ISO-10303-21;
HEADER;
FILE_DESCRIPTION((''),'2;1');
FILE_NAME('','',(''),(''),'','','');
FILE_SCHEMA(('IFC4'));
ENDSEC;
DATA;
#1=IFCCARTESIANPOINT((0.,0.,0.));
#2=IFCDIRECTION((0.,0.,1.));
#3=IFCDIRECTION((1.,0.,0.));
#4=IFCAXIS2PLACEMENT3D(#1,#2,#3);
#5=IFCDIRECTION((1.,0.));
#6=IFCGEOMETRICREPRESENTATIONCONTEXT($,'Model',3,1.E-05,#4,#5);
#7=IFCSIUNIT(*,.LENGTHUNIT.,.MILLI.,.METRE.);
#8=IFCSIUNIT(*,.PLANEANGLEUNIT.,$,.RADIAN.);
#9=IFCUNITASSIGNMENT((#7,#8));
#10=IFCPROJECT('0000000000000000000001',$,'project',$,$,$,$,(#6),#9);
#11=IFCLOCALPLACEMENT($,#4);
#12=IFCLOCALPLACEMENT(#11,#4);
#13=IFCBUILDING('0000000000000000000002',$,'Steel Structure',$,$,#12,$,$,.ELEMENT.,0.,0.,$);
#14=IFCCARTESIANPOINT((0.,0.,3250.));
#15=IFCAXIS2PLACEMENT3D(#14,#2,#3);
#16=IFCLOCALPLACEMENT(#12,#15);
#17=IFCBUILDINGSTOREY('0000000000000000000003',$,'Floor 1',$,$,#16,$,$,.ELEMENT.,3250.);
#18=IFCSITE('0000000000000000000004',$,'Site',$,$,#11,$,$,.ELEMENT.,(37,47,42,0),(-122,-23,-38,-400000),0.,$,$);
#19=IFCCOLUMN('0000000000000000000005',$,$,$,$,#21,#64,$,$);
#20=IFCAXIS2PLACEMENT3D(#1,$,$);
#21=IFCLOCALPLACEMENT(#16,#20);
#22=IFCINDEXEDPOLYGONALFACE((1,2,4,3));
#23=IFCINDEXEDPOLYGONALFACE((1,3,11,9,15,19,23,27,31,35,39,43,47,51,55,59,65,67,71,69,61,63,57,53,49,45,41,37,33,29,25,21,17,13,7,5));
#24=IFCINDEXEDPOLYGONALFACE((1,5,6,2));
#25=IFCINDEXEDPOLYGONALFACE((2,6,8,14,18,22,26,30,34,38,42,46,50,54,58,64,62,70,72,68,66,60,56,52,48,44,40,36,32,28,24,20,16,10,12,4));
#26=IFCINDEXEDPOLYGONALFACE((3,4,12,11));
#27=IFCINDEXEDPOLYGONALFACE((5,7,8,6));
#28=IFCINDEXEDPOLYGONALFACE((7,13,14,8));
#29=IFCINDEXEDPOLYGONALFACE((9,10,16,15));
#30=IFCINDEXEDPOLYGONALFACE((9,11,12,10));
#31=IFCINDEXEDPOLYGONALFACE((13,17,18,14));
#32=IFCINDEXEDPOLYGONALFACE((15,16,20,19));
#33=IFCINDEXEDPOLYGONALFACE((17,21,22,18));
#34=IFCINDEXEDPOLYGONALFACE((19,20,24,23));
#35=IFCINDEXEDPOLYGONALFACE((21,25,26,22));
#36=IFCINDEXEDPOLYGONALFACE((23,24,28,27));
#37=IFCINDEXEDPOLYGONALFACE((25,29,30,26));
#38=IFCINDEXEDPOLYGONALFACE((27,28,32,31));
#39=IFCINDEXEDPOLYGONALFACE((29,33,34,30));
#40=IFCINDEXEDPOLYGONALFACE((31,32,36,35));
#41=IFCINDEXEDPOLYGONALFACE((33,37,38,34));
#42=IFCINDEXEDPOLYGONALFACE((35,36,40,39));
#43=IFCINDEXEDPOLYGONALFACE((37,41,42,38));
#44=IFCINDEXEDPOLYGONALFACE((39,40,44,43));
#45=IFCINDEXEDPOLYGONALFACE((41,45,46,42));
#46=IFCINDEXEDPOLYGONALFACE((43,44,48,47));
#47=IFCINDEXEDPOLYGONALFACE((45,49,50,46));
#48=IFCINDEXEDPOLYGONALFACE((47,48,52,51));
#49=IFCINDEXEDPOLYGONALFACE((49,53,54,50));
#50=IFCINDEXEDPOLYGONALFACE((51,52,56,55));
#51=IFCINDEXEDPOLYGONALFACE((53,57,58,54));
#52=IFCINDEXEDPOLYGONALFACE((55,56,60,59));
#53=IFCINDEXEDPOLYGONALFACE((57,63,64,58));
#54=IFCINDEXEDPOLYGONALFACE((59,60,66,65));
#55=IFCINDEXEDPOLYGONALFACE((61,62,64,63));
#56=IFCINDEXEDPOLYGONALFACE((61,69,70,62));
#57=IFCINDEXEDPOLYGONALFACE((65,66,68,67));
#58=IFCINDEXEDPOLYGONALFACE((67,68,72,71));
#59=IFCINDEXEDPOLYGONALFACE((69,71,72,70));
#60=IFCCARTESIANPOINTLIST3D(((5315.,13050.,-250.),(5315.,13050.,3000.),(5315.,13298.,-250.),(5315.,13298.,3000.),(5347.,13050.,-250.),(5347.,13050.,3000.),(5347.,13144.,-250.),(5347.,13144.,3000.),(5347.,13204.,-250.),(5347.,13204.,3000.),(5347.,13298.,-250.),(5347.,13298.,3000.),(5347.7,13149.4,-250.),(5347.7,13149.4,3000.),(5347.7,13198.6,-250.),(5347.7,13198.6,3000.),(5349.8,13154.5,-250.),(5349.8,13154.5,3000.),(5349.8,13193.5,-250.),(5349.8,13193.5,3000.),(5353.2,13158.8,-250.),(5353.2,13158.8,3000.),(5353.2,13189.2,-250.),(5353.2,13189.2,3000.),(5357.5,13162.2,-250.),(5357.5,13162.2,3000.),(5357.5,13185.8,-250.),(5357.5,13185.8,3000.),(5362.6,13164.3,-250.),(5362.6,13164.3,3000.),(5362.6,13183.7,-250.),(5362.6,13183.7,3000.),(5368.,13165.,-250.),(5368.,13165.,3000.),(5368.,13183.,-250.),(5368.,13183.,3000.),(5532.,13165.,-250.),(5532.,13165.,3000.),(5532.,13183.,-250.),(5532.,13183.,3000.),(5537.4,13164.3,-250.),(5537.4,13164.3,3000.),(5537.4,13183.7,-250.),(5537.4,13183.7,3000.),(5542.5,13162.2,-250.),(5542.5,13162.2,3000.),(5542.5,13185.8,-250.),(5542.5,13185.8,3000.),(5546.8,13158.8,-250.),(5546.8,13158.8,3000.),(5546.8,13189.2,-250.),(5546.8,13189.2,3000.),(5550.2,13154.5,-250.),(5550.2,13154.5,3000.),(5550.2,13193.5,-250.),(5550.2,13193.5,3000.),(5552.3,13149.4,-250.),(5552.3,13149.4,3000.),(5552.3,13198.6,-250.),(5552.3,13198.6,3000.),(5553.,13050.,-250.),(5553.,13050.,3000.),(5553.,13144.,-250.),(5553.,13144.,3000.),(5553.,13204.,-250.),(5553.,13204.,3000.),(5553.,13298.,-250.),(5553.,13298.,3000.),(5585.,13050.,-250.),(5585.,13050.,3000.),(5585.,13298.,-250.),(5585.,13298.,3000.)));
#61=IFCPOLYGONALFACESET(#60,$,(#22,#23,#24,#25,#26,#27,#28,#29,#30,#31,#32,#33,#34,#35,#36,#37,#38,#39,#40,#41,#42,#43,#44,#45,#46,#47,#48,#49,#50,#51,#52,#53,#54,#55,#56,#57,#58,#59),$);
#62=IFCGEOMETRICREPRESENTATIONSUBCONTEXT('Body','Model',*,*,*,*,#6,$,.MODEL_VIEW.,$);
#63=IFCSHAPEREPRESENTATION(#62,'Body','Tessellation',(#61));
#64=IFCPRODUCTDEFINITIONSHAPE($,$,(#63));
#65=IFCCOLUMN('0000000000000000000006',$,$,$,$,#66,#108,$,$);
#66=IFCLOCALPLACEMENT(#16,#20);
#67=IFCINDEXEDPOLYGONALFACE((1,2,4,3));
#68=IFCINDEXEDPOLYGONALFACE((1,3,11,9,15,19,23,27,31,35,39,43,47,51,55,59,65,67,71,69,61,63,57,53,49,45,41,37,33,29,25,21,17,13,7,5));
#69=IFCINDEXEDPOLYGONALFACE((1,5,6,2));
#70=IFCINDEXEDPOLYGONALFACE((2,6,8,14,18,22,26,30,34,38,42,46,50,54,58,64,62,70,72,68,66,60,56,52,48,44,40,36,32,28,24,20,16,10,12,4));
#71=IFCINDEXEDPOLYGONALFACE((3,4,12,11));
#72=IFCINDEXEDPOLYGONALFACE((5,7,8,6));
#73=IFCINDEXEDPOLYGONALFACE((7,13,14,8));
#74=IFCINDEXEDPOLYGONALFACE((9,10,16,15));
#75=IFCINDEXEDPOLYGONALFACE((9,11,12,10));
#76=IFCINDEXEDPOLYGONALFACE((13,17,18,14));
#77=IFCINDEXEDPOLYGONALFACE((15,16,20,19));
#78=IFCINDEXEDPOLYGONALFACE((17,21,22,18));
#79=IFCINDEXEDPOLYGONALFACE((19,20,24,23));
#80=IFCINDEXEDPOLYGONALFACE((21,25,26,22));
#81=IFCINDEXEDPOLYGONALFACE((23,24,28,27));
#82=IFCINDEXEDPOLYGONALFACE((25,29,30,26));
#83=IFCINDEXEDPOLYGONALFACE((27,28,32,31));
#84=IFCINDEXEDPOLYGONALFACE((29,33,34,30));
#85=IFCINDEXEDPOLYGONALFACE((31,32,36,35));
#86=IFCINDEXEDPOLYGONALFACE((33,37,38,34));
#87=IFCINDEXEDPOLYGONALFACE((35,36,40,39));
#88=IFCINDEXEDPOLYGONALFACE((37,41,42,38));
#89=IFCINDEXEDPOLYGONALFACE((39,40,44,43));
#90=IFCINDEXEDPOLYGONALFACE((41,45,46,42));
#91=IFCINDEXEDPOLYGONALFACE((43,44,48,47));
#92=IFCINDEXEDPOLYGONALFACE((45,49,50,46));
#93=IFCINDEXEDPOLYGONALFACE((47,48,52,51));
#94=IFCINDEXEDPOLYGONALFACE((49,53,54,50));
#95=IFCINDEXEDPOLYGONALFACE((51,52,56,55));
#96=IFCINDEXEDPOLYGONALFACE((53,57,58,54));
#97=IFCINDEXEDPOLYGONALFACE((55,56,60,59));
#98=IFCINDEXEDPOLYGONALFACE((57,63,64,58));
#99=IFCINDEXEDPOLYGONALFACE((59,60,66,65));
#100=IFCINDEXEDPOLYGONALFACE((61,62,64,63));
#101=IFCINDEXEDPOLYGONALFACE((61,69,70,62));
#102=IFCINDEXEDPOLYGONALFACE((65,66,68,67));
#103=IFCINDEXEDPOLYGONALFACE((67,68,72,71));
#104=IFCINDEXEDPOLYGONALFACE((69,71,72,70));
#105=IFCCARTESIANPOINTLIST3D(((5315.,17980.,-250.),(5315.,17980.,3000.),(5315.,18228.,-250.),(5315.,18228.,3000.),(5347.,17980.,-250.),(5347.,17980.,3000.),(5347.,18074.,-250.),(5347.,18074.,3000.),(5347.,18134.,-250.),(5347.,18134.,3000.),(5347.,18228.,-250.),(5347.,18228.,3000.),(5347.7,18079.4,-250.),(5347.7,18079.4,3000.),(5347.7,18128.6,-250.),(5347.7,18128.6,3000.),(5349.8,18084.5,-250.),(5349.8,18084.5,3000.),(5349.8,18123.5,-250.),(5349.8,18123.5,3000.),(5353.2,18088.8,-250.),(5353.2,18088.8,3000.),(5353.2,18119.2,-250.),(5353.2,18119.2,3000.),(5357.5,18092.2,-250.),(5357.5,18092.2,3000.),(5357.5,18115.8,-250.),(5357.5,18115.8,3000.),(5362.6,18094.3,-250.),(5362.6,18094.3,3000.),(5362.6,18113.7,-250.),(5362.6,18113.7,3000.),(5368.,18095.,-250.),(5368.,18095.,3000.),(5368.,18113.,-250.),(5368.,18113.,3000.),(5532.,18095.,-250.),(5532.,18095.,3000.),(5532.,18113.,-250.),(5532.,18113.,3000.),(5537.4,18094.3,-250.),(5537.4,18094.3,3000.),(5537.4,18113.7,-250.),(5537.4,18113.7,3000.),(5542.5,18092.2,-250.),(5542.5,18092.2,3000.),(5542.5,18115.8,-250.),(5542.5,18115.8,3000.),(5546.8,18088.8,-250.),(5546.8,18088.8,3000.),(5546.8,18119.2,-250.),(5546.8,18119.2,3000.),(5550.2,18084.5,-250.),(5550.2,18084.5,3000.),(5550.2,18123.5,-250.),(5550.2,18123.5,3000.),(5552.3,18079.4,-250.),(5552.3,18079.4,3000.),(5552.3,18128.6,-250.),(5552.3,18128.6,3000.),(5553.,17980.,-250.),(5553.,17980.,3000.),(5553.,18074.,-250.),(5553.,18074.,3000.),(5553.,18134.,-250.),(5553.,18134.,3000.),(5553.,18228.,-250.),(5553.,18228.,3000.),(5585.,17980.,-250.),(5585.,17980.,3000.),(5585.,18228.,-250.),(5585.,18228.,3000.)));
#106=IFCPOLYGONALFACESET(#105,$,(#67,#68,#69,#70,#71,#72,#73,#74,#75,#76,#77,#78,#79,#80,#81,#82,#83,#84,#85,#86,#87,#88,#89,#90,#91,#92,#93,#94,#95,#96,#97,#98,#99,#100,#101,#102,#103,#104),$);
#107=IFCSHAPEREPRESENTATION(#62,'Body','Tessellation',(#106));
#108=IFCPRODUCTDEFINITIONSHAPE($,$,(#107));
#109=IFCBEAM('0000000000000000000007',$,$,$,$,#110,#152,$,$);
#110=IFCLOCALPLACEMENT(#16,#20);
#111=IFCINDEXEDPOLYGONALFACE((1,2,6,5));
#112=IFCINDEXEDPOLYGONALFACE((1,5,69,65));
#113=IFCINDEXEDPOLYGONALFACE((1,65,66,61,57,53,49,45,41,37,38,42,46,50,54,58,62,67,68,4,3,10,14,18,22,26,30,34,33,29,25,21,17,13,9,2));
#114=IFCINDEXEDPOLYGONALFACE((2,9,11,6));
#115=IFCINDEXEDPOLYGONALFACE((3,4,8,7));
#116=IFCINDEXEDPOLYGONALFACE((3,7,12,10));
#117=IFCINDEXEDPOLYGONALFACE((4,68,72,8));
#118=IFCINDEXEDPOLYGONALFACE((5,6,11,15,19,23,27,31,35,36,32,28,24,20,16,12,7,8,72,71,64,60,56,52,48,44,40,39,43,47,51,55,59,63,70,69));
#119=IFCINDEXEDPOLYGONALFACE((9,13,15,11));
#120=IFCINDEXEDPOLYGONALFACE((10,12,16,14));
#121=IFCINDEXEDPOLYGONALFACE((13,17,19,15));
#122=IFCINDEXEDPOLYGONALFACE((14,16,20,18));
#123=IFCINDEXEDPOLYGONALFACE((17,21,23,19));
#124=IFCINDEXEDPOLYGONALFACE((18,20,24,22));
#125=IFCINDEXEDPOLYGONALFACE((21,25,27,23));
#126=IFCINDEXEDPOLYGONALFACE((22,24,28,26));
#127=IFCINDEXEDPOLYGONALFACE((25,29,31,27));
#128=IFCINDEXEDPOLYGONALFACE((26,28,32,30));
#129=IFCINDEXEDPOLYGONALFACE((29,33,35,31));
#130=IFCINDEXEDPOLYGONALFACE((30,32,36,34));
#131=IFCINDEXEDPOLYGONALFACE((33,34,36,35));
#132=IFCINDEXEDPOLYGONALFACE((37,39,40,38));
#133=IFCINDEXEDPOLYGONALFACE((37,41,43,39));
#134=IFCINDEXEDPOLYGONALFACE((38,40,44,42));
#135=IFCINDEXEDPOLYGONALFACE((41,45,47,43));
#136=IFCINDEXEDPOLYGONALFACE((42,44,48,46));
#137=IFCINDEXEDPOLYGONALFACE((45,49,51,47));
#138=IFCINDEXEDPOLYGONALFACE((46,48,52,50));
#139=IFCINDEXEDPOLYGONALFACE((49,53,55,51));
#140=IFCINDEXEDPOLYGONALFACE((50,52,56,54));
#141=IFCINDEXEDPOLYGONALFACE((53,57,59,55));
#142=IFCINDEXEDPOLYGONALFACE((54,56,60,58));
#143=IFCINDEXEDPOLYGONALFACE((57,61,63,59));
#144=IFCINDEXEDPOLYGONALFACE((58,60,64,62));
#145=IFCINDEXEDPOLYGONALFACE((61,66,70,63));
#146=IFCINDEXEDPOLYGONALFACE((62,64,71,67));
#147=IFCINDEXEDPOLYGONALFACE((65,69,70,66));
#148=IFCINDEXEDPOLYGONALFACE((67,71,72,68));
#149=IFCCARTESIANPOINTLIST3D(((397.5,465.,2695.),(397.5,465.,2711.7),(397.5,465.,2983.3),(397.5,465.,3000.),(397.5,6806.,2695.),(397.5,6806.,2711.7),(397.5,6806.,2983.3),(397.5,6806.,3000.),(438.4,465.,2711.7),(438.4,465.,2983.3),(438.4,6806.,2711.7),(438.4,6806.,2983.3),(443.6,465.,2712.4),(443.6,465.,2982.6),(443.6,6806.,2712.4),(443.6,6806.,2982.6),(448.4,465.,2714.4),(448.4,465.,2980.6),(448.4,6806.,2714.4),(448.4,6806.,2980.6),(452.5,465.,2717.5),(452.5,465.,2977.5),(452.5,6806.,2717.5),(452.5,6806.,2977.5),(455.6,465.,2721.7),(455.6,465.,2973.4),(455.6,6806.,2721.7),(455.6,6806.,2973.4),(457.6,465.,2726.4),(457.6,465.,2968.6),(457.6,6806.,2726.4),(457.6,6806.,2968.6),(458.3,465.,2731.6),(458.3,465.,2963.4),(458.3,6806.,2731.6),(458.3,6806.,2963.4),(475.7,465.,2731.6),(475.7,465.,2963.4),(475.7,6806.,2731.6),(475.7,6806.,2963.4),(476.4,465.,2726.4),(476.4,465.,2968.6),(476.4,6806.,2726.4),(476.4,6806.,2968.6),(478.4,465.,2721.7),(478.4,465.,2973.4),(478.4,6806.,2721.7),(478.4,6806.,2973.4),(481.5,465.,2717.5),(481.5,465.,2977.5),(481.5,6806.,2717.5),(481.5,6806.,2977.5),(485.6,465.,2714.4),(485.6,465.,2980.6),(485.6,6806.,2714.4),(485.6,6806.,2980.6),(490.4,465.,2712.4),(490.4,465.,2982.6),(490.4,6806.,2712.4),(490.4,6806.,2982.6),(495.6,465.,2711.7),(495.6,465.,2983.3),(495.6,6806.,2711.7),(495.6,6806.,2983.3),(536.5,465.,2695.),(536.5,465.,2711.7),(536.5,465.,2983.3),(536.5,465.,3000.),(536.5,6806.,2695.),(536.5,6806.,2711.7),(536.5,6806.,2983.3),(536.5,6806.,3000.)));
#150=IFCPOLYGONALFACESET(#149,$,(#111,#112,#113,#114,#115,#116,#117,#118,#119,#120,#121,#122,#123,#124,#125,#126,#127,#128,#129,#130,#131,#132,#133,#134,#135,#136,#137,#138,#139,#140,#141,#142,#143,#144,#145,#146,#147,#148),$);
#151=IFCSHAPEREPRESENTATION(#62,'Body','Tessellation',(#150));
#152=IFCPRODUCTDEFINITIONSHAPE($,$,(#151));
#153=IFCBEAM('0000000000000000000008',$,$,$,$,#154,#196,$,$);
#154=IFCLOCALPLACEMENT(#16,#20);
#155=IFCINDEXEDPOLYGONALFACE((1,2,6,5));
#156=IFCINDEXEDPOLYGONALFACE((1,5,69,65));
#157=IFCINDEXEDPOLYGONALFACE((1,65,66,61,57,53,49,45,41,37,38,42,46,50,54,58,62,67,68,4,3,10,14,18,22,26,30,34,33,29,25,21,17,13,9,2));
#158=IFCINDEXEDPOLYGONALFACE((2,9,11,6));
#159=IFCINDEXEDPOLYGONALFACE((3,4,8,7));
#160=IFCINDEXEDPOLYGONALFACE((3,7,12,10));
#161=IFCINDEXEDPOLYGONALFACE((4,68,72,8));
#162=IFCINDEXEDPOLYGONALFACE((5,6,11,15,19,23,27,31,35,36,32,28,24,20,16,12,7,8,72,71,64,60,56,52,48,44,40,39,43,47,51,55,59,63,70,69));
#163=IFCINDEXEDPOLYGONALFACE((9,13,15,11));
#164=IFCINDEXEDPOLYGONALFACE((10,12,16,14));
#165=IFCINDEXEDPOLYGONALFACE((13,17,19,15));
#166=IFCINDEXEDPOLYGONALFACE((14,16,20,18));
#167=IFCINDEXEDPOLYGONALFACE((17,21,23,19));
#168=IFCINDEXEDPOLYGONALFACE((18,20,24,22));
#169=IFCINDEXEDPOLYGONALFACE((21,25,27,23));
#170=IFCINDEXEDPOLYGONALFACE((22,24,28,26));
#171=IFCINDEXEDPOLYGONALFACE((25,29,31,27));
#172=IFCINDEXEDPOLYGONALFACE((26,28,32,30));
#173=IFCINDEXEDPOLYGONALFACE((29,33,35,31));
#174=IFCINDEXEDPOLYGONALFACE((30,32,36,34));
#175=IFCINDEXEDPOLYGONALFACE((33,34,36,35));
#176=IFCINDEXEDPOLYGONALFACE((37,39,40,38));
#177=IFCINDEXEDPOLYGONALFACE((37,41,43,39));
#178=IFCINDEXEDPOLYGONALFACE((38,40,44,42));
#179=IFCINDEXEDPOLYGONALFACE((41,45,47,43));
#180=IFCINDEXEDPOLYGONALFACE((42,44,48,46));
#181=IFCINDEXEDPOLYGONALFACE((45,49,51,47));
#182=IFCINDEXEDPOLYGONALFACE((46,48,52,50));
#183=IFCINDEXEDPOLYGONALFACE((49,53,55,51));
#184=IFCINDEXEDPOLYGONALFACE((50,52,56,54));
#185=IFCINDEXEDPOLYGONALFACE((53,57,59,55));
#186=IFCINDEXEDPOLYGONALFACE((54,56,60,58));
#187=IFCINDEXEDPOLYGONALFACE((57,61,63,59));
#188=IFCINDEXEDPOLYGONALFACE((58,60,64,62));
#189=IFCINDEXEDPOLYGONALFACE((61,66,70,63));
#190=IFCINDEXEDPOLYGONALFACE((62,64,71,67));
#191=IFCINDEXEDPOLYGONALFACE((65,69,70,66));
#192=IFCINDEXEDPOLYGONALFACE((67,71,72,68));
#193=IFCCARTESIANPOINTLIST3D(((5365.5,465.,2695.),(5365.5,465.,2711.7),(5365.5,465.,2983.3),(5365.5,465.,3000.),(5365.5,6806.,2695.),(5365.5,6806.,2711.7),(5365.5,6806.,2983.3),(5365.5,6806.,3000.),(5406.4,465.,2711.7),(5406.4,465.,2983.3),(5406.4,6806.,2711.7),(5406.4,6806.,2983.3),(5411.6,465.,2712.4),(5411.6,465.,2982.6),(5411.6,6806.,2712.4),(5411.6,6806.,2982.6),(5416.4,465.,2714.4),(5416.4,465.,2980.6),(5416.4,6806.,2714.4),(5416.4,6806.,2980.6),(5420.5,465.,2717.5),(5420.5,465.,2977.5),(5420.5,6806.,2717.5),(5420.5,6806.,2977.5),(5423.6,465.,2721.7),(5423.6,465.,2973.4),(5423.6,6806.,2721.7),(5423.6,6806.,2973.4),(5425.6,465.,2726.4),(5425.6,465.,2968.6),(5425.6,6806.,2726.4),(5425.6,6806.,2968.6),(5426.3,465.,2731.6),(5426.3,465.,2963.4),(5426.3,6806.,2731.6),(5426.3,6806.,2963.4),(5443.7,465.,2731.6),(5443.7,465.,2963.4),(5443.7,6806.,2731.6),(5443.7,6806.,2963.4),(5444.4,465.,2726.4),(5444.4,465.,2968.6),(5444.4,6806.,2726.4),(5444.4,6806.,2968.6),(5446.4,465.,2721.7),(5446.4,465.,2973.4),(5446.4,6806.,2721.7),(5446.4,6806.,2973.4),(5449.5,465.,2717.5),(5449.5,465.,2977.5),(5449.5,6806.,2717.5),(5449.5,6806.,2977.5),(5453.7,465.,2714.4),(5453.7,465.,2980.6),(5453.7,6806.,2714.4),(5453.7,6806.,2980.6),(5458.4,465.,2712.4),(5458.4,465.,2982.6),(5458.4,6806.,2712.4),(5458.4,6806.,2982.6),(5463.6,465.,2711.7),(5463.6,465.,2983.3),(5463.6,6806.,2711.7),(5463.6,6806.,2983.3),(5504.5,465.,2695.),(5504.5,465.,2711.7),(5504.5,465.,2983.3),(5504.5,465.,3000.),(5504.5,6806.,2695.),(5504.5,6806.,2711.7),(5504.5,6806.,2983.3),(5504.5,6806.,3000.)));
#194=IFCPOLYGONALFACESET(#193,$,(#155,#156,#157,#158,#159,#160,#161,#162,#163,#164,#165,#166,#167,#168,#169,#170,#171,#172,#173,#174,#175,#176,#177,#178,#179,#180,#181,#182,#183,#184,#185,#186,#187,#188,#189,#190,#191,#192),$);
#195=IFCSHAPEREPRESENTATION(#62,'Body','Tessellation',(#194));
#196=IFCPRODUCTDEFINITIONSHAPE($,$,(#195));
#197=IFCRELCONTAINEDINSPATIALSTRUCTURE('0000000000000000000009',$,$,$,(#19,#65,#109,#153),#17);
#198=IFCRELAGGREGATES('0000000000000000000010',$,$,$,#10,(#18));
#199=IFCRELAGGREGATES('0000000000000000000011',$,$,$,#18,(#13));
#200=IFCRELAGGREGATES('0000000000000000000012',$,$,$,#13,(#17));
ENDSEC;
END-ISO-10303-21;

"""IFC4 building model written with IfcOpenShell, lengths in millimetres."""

from ifc_helpers import new_model, si_unit, direction, frame, origin_with_axes, origin_2d_with_axis, place, context, subcontext, project, spatial, i_section, extrude, element, save


model = new_model("IFC4")

# Units and contexts
model_context = context("Model", 3, precision=1e-05, world=origin_with_axes(), true_north=direction((1.0, 0.0)))
body_context = subcontext(model_context, "Body", "Model", "MODEL_VIEW")
ifc_project = project(units=[si_unit("LENGTHUNIT", "METRE", prefix="MILLI"), si_unit("PLANEANGLEUNIT", "RADIAN")], contexts=[model_context])

# Site, building, storey
site_placement = place(None, origin_with_axes())
site = spatial("IfcSite", under=ifc_project, at=site_placement, Name="Site", CompositionType="ELEMENT", RefLatitude=(37, 47, 42, 0), RefLongitude=(-122, -23, -38, -400000), RefElevation=0.0)
building_placement = place(site_placement, origin_with_axes())
building = spatial("IfcBuilding", under=site, at=building_placement, Name="Steel Structure", CompositionType="ELEMENT", ElevationOfRefHeight=0.0, ElevationOfTerrain=0.0)
storey_placement = place(building_placement, frame((0.0, 0.0, 3250.0), z_axis=(0.0, 0.0, 1.0), x_axis=(1.0, 0.0, 0.0)))
storey = spatial("IfcBuildingStorey", under=building, at=storey_placement, Name="Floor 1", CompositionType="ELEMENT", Elevation=3250.0)

# Columns
for number, where, z_axis, x_axis in (
    (1, (5450.0, 13174.0, -250.0), (0.0, 0.0, 1.0), (0.0, 1.0, 0.0)),
):
    element("IfcColumn", number, at=place(storey_placement, frame(where, z_axis=z_axis, x_axis=x_axis)), inside=storey, context=body_context, shape_type="SweptSolid", body=[
        extrude(i_section(OverallWidth=248.0, OverallDepth=270.0, WebThickness=18.0, FlangeThickness=32.0, FilletRadius=21.0, at=origin_2d_with_axis()), origin_with_axes(), (0.0, 0.0, 1.0), 3250.0),
    ])
column_1_placement = place(storey_placement, frame((5450.0, 18104.0, -250.0), z_axis=(0.0, 0.0, 1.0), x_axis=(0.0, 1.0, 0.0)))
element("IfcColumn", 2, at=column_1_placement, inside=storey, context=body_context, shape_type="SweptSolid", body=[
    extrude(i_section(OverallWidth=248.0, OverallDepth=270.0, WebThickness=18.0, FlangeThickness=32.0, FilletRadius=21.0, at=origin_2d_with_axis()), origin_with_axes(), (0.0, 0.0, 1.0), 3250.0),
])

# Beams
beam_1_placement = place(storey_placement, frame((467.0, 465.0, 2847.5), z_axis=(0.0, 1.0, 0.0), x_axis=(-1.0, 0.0, 0.0)))
element("IfcBeam", 3, at=beam_1_placement, inside=storey, context=body_context, shape_type="SweptSolid", body=[
    extrude(i_section(OverallWidth=139.0, OverallDepth=305.0, WebThickness=17.4, FlangeThickness=16.7, FilletRadius=19.9, at=origin_2d_with_axis()), origin_with_axes(), (0.0, 0.0, 1.0), 6341.0),
])
beam_2_placement = place(storey_placement, frame((5435.0, 465.0, 2847.5), z_axis=(0.0, 1.0, 0.0), x_axis=(-1.0, 0.0, 0.0)))
element("IfcBeam", 4, at=beam_2_placement, inside=storey, context=body_context, shape_type="SweptSolid", body=[
    extrude(i_section(OverallWidth=139.0, OverallDepth=305.0, WebThickness=17.4, FlangeThickness=16.7, FilletRadius=19.9, at=origin_2d_with_axis()), origin_with_axes(), (0.0, 0.0, 1.0), 6341.0),
])

save(model, "model.ifc")
